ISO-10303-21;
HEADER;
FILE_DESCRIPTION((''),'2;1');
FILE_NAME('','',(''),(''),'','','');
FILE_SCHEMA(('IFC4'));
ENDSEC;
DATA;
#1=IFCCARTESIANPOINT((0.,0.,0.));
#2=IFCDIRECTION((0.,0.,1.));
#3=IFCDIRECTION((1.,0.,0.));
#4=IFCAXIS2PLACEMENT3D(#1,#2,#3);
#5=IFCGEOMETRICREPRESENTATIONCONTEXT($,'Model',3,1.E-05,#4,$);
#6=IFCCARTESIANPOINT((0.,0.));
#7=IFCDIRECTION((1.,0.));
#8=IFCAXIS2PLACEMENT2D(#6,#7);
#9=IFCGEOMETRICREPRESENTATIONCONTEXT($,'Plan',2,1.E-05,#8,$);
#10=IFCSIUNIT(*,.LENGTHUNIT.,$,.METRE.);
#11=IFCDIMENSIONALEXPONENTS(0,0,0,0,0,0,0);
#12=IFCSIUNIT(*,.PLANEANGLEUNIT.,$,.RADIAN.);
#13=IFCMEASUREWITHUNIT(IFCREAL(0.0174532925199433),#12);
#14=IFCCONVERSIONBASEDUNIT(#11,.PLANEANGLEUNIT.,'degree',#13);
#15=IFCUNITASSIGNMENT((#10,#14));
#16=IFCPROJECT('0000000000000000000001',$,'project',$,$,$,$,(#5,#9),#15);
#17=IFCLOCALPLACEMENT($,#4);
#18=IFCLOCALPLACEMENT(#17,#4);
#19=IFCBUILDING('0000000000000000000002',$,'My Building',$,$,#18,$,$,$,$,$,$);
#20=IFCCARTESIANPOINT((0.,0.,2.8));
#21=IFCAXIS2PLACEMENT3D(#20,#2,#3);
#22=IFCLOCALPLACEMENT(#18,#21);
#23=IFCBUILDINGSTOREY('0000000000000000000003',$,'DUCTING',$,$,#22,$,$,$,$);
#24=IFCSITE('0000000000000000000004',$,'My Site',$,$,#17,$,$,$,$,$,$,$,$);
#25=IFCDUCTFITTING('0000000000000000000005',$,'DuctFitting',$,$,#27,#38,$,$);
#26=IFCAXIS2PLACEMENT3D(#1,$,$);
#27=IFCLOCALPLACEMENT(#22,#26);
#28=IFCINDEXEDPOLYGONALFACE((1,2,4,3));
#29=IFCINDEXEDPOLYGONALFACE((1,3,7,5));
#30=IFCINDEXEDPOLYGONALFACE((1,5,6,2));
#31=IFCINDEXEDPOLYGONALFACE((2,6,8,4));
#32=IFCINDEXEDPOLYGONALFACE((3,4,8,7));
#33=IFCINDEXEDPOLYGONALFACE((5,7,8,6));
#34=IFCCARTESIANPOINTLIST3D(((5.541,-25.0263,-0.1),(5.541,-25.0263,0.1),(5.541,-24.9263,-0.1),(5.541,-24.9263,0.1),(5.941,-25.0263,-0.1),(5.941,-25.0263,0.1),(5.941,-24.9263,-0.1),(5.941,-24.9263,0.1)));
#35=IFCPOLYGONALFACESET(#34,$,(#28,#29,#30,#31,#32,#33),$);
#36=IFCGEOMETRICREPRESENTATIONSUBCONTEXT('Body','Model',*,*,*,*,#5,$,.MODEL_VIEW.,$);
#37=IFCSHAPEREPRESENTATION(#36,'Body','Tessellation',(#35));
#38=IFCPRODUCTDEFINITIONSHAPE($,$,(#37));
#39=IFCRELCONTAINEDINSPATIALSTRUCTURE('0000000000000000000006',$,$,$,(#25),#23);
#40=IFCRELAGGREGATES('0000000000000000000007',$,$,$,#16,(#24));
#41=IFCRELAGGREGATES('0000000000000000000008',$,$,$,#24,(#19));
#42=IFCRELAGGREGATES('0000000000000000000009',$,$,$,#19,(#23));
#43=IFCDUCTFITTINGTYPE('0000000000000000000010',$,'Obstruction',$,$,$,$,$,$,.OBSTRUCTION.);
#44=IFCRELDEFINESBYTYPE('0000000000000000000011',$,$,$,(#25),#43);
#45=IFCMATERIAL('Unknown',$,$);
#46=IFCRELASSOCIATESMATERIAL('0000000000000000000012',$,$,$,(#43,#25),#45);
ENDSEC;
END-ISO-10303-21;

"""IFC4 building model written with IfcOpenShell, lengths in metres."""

from ifc_helpers import new_model, entity, si_unit, converted_unit, frame, origin_with_axes, origin_2d_with_axis, place, context, subcontext, project, spatial, rectangle, extrude, material, material_profile, profile_set, profile_usage, type_object, element, save


model = new_model("IFC4")

# Units and contexts
model_context = context("Model", 3, precision=1e-05, world=origin_with_axes())
plan_context = context("Plan", 2, precision=1e-05, world=origin_2d_with_axis())
body_context = subcontext(model_context, "Body", "Model", "MODEL_VIEW")
ifc_project = project(units=[si_unit("LENGTHUNIT", "METRE"), converted_unit("PLANEANGLEUNIT", "degree", entity("IfcReal", 0.0174532925199433), si_unit("PLANEANGLEUNIT", "RADIAN"), dimensions=[0, 0, 0, 0, 0, 0, 0])], contexts=[model_context, plan_context])

# Site, building, storey
site_placement = place(None, origin_with_axes())
site = spatial("IfcSite", under=ifc_project, at=site_placement, Name="My Site")
building_placement = place(site_placement, origin_with_axes())
building = spatial("IfcBuilding", under=site, at=building_placement, Name="My Building")
storey_placement = place(building_placement, frame((0.0, 0.0, 2.8), z_axis=(0.0, 0.0, 1.0), x_axis=(1.0, 0.0, 0.0)))
storey = spatial("IfcBuildingStorey", under=building, at=storey_placement, Name="DUCTING")

# Shared definitions
ifc_material = material(Name="Unknown")

# Duct fitting
ifc_material_profile_1 = material_profile(ifc_material, rectangle(XDim=0.4, YDim=0.2))
ifc_profile_set_1 = profile_set([ifc_material_profile_1])
duct_fitting_type_1 = type_object("IfcDuctFittingType", Name="Obstruction", PredefinedType="OBSTRUCTION", material=ifc_profile_set_1)
ifc_profile_usage_1 = profile_usage(ifc_profile_set_1, cardinal=5)
duct_fitting_1_placement = place(storey_placement, frame((5.741, -24.9263, 0.0), z_axis=(0.0, -1.0, 0.0), x_axis=(1.0, 0.0, 0.0)))
element("IfcDuctFitting", 1, at=duct_fitting_1_placement, inside=storey, type_object=duct_fitting_type_1, material=ifc_profile_usage_1, Name="DuctFitting", context=body_context, shape_type="SweptSolid", body=[
    extrude(rectangle(XDim=0.4, YDim=0.2), origin_with_axes(), (0.0, 0.0, 1.0), 0.1),
])

save(model, "model.ifc")
